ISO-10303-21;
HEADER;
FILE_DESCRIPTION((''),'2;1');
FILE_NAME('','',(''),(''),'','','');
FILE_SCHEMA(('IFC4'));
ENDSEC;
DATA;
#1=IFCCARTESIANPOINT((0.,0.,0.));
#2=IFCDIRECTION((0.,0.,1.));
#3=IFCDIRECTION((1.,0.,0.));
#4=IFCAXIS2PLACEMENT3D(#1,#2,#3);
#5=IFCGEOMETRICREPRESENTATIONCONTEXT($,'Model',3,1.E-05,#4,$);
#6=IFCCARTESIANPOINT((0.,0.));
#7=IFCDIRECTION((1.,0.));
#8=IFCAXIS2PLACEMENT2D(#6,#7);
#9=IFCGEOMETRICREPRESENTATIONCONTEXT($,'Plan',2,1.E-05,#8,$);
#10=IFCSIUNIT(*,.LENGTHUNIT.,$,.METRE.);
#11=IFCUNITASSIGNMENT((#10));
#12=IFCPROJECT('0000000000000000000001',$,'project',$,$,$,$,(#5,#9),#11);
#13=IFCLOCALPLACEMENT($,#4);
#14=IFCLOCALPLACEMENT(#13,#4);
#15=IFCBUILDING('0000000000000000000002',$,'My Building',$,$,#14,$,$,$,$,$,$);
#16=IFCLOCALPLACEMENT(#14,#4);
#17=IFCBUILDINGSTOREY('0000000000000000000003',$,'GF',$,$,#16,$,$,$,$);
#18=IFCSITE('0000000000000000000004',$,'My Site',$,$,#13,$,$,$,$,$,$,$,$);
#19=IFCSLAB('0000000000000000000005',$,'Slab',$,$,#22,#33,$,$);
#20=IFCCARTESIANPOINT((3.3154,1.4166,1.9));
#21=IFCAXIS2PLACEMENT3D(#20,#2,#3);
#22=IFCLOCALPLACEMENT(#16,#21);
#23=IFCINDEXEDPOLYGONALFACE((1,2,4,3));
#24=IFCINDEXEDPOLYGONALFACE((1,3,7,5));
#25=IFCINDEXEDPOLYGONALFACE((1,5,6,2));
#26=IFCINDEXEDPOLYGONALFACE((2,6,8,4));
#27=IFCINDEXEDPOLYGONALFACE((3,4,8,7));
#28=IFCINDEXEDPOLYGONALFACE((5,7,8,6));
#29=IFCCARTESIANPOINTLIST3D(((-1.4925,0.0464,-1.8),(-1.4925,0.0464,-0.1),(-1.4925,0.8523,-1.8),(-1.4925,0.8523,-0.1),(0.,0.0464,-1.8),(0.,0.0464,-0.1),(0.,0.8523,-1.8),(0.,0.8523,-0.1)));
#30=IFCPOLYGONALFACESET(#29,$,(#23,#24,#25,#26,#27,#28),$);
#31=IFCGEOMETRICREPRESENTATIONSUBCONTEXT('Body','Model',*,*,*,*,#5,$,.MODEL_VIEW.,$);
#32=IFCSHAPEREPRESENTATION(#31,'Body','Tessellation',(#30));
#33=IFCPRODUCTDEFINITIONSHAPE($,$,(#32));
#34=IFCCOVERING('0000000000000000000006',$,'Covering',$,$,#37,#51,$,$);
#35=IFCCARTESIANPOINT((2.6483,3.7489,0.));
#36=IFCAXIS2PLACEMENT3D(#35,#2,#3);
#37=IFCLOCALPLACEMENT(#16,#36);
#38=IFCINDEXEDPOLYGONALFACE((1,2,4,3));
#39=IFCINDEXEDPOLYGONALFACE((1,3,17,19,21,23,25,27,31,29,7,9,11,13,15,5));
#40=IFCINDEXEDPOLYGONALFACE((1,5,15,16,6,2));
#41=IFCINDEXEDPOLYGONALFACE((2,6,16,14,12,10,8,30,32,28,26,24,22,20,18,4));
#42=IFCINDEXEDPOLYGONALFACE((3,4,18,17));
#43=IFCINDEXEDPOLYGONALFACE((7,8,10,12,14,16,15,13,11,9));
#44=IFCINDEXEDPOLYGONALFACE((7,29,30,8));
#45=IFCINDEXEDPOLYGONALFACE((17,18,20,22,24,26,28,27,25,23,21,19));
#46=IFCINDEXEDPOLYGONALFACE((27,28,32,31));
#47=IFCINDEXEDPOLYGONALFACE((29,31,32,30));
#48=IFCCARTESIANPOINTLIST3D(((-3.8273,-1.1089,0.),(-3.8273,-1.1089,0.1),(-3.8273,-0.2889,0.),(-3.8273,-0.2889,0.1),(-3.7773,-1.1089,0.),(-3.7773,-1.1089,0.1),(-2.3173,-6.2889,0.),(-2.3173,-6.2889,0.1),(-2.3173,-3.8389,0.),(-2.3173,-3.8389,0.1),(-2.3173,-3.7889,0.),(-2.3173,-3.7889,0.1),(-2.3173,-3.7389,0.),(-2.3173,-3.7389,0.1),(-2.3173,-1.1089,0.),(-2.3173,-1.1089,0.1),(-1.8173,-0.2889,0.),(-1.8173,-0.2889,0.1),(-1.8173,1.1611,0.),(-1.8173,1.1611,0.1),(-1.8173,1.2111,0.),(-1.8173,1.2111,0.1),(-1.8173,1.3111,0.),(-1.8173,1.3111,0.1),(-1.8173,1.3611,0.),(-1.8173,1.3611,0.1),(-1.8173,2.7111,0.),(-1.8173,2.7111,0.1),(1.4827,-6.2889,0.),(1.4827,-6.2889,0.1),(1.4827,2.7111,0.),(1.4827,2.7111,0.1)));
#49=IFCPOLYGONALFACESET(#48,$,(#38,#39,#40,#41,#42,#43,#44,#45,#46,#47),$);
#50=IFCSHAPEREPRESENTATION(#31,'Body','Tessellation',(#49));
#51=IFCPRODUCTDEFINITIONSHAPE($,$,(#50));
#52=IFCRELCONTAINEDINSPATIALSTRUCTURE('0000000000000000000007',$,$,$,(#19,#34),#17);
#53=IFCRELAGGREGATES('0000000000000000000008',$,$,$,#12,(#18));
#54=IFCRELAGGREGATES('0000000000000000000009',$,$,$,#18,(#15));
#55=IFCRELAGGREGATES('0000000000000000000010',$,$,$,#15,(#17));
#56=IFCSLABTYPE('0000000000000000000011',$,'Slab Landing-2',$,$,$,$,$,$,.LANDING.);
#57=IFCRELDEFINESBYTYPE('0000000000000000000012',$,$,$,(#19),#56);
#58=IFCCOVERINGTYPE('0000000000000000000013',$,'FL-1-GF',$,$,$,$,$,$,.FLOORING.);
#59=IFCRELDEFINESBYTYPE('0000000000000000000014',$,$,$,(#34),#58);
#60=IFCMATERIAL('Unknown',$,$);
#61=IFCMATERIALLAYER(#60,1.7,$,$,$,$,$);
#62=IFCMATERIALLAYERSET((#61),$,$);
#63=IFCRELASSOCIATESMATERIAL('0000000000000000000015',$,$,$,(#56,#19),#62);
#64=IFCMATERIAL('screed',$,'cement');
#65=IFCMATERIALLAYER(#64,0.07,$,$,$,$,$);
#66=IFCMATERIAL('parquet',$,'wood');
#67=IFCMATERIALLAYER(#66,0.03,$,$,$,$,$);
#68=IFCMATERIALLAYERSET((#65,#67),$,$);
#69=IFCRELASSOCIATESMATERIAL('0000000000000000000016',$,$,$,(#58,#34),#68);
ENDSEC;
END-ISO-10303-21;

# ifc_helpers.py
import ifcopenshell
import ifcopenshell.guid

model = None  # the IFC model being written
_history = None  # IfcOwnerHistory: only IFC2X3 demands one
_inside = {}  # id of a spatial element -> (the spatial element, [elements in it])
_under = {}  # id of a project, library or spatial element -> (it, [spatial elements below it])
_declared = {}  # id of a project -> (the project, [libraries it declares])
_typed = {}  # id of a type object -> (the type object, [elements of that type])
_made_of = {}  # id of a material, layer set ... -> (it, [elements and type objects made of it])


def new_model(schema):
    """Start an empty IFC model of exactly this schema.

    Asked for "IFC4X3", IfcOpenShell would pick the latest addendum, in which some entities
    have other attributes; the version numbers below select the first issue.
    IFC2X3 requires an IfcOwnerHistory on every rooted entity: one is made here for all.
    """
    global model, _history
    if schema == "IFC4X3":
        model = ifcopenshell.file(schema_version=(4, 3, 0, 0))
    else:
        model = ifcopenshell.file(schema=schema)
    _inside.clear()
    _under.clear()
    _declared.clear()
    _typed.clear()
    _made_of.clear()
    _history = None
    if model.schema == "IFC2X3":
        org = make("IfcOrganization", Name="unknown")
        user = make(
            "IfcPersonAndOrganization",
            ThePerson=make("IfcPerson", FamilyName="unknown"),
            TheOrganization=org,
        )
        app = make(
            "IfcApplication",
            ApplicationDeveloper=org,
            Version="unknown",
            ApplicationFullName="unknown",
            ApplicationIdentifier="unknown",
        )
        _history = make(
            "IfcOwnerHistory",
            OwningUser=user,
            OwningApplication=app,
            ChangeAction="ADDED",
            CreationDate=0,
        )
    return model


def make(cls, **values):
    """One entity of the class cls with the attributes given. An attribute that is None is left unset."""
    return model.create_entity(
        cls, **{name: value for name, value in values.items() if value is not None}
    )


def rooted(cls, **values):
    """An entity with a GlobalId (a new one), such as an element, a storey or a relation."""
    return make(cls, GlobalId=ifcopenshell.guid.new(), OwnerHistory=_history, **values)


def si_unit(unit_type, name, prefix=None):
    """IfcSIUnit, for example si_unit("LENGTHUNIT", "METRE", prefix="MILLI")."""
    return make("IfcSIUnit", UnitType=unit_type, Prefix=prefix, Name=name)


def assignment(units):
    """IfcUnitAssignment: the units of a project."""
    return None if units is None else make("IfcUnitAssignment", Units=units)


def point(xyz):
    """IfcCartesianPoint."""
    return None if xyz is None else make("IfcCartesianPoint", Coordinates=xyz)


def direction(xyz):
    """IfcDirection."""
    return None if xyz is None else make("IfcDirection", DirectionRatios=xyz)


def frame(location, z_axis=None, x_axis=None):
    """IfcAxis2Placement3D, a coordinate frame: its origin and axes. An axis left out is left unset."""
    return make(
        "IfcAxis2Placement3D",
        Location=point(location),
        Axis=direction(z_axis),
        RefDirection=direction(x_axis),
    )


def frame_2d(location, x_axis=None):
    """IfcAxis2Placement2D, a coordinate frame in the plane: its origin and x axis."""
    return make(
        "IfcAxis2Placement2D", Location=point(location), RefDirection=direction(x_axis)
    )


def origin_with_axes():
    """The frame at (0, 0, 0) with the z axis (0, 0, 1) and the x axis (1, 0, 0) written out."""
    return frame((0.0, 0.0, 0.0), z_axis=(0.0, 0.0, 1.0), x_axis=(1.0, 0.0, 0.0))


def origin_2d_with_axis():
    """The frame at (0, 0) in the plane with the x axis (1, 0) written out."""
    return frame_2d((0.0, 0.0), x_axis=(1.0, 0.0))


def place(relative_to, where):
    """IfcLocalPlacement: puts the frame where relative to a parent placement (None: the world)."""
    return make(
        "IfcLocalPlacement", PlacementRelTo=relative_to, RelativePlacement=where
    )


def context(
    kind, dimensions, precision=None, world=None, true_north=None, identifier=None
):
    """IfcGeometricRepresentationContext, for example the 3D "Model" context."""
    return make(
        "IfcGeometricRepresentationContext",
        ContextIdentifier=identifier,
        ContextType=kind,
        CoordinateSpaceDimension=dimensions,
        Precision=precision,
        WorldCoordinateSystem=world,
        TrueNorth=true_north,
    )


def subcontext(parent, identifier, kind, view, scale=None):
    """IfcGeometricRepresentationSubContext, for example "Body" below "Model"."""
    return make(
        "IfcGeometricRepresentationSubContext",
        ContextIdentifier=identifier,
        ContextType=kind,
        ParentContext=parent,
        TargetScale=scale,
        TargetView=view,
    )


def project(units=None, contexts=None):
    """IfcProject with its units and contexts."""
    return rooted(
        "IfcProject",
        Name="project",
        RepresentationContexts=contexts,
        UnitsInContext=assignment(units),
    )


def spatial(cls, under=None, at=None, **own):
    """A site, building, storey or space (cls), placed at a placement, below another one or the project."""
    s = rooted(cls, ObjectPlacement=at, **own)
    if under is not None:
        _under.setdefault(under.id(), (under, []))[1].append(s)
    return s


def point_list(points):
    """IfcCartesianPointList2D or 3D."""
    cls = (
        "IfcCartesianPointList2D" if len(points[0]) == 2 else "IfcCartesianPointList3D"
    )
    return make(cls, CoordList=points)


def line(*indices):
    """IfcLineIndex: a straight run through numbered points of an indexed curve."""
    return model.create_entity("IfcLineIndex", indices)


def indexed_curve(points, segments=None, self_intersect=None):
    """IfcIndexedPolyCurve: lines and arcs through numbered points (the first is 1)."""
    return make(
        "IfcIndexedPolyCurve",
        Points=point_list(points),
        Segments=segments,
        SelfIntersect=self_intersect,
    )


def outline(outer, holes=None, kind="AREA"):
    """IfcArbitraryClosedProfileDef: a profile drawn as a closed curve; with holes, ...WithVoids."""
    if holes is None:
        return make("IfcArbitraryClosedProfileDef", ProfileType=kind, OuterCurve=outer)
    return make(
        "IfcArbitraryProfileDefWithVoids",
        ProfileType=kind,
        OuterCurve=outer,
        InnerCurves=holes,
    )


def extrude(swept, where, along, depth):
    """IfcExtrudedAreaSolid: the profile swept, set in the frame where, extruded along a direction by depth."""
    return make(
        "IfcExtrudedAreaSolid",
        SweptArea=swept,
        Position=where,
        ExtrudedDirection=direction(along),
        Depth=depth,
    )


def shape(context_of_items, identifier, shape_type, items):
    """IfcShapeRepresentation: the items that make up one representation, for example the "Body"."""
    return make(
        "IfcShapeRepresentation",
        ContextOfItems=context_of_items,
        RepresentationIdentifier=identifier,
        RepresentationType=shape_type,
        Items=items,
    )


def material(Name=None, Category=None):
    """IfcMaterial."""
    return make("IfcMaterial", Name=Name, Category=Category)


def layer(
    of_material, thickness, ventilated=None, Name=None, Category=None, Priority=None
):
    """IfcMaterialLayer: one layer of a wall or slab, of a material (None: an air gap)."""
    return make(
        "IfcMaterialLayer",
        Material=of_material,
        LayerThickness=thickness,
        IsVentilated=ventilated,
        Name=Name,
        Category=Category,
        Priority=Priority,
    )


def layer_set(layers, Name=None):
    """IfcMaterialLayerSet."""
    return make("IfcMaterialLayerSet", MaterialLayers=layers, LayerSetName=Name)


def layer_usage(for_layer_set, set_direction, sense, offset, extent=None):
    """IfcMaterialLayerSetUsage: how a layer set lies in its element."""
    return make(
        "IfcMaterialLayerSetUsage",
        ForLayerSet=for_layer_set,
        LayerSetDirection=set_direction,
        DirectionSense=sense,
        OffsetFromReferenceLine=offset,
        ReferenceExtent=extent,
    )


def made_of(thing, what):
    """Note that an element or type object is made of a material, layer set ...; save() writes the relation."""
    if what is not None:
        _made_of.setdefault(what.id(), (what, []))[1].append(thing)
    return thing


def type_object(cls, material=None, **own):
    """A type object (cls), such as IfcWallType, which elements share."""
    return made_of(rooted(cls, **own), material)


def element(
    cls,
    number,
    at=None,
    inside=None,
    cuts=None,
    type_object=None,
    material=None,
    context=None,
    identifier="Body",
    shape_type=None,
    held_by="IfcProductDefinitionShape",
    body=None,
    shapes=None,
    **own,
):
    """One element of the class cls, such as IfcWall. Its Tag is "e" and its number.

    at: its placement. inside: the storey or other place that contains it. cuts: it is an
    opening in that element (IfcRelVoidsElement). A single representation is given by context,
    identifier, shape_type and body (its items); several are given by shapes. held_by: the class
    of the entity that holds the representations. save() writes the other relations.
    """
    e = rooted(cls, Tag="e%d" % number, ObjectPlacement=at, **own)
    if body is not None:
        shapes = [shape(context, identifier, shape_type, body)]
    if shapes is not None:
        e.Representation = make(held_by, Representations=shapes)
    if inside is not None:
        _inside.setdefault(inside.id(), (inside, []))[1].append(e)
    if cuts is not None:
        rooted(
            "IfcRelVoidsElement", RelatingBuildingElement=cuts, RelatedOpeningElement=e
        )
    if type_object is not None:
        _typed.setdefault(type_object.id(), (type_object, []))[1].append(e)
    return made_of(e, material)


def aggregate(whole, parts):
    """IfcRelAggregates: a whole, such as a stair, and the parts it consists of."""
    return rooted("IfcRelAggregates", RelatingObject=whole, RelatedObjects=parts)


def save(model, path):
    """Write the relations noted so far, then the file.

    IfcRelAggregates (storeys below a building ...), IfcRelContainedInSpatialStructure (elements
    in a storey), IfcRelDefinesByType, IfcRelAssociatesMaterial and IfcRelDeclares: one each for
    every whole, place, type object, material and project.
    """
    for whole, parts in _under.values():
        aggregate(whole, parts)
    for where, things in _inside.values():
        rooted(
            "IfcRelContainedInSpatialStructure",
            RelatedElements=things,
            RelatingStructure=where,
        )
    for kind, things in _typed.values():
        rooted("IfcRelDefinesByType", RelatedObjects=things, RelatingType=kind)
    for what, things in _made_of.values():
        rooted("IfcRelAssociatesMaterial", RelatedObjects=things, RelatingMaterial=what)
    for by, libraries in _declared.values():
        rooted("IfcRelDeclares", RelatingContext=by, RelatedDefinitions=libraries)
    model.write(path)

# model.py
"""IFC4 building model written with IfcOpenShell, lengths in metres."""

from ifc_helpers import new_model, si_unit, frame, origin_with_axes, origin_2d_with_axis, place, context, subcontext, project, spatial, line, indexed_curve, outline, extrude, material, layer, layer_set, layer_usage, type_object, element, save


model = new_model("IFC4")

# Units and contexts
model_context = context("Model", 3, precision=1e-05, world=origin_with_axes())
plan_context = context("Plan", 2, precision=1e-05, world=origin_2d_with_axis())
body_context_1 = subcontext(model_context, "Body", "Model", "MODEL_VIEW")
ifc_project = project(units=[si_unit("LENGTHUNIT", "METRE")], contexts=[model_context, plan_context])

# Site, building, storey
site_placement = place(None, origin_with_axes())
site = spatial("IfcSite", under=ifc_project, at=site_placement, Name="My Site")
building_placement = place(site_placement, origin_with_axes())
building = spatial("IfcBuilding", under=site, at=building_placement, Name="My Building")
storey_placement = place(building_placement, origin_with_axes())
storey = spatial("IfcBuildingStorey", under=building, at=storey_placement, Name="GF")

# Slab
ifc_material_1 = material(Name="Unknown")
ifc_layer_1 = layer(ifc_material_1, 1.7)
ifc_layer_set_1 = layer_set([ifc_layer_1])
ifc_layer_usage_1 = layer_usage(ifc_layer_set_1, "AXIS3", "POSITIVE", -1.8)
slab_type_1 = type_object("IfcSlabType", Name="Slab Landing-2", PredefinedType="LANDING", material=ifc_layer_set_1)
slab_1_placement = place(storey_placement, frame((3.3154, 1.4166, 1.9), z_axis=(0.0, 0.0, 1.0), x_axis=(1.0, 0.0, 0.0)))
element("IfcSlab", 1, at=slab_1_placement, inside=storey, type_object=slab_type_1, material=ifc_layer_usage_1, Name="Slab", context=body_context_1, shape_type="SweptSolid", body=[
    extrude(outline(indexed_curve([(0.0, 0.8523), (-1.4925, 0.8523), (-1.4925, 0.0464), (0.0, 0.0464), (0.0, 0.8523)])), frame((0.0, 0.0, -1.8), z_axis=(0.0, 0.0, 1.0), x_axis=(1.0, 0.0, 0.0)), (0.0, 0.0, 1.0), 1.7),
])

# Covering
ifc_material_2 = material(Name="screed", Category="cement")
ifc_layer_2 = layer(ifc_material_2, 0.07)
ifc_material_3 = material(Name="parquet", Category="wood")
ifc_layer_3 = layer(ifc_material_3, 0.03)
ifc_layer_set_2 = layer_set([ifc_layer_2, ifc_layer_3])
ifc_layer_usage_2 = layer_usage(ifc_layer_set_2, "AXIS3", "POSITIVE", 0.0)
covering_type = type_object("IfcCoveringType", Name="FL-1-GF", PredefinedType="FLOORING", material=ifc_layer_set_2)
covering_placement = place(storey_placement, frame((2.6483, 3.7489, 0.0), z_axis=(0.0, 0.0, 1.0), x_axis=(1.0, 0.0, 0.0)))
element("IfcCovering", 2, at=covering_placement, inside=storey, type_object=covering_type, material=ifc_layer_usage_2, Name="Covering", context=body_context_1, shape_type="SweptSolid", body=[
    extrude(outline(indexed_curve([(-2.3173, -1.1089), (-3.7773, -1.1089), (-3.8273, -1.1089), (-3.8273, -0.2889), (-1.8173, -0.2889), (-1.8173, 1.1611), (-1.8173, 1.2111), (-1.8173, 1.3111), (-1.8173, 1.3611), (-1.8173, 2.7111), (1.4827, 2.7111), (1.4827, -6.2889), (-2.3173, -6.2889), (-2.3173, -6.2889), (-2.3173, -3.8389), (-2.3173, -3.7889), (-2.3173, -3.7889), (-2.3173, -3.7389)], segments=[line(1, 2, 3, 4, 5, 6, 7, 8, 9, 10, 11, 12, 13, 14, 15, 16, 17, 18, 1)])), origin_with_axes(), (0.0, 0.0, 1.0), 0.1),
])

save(model, "model.ifc")
